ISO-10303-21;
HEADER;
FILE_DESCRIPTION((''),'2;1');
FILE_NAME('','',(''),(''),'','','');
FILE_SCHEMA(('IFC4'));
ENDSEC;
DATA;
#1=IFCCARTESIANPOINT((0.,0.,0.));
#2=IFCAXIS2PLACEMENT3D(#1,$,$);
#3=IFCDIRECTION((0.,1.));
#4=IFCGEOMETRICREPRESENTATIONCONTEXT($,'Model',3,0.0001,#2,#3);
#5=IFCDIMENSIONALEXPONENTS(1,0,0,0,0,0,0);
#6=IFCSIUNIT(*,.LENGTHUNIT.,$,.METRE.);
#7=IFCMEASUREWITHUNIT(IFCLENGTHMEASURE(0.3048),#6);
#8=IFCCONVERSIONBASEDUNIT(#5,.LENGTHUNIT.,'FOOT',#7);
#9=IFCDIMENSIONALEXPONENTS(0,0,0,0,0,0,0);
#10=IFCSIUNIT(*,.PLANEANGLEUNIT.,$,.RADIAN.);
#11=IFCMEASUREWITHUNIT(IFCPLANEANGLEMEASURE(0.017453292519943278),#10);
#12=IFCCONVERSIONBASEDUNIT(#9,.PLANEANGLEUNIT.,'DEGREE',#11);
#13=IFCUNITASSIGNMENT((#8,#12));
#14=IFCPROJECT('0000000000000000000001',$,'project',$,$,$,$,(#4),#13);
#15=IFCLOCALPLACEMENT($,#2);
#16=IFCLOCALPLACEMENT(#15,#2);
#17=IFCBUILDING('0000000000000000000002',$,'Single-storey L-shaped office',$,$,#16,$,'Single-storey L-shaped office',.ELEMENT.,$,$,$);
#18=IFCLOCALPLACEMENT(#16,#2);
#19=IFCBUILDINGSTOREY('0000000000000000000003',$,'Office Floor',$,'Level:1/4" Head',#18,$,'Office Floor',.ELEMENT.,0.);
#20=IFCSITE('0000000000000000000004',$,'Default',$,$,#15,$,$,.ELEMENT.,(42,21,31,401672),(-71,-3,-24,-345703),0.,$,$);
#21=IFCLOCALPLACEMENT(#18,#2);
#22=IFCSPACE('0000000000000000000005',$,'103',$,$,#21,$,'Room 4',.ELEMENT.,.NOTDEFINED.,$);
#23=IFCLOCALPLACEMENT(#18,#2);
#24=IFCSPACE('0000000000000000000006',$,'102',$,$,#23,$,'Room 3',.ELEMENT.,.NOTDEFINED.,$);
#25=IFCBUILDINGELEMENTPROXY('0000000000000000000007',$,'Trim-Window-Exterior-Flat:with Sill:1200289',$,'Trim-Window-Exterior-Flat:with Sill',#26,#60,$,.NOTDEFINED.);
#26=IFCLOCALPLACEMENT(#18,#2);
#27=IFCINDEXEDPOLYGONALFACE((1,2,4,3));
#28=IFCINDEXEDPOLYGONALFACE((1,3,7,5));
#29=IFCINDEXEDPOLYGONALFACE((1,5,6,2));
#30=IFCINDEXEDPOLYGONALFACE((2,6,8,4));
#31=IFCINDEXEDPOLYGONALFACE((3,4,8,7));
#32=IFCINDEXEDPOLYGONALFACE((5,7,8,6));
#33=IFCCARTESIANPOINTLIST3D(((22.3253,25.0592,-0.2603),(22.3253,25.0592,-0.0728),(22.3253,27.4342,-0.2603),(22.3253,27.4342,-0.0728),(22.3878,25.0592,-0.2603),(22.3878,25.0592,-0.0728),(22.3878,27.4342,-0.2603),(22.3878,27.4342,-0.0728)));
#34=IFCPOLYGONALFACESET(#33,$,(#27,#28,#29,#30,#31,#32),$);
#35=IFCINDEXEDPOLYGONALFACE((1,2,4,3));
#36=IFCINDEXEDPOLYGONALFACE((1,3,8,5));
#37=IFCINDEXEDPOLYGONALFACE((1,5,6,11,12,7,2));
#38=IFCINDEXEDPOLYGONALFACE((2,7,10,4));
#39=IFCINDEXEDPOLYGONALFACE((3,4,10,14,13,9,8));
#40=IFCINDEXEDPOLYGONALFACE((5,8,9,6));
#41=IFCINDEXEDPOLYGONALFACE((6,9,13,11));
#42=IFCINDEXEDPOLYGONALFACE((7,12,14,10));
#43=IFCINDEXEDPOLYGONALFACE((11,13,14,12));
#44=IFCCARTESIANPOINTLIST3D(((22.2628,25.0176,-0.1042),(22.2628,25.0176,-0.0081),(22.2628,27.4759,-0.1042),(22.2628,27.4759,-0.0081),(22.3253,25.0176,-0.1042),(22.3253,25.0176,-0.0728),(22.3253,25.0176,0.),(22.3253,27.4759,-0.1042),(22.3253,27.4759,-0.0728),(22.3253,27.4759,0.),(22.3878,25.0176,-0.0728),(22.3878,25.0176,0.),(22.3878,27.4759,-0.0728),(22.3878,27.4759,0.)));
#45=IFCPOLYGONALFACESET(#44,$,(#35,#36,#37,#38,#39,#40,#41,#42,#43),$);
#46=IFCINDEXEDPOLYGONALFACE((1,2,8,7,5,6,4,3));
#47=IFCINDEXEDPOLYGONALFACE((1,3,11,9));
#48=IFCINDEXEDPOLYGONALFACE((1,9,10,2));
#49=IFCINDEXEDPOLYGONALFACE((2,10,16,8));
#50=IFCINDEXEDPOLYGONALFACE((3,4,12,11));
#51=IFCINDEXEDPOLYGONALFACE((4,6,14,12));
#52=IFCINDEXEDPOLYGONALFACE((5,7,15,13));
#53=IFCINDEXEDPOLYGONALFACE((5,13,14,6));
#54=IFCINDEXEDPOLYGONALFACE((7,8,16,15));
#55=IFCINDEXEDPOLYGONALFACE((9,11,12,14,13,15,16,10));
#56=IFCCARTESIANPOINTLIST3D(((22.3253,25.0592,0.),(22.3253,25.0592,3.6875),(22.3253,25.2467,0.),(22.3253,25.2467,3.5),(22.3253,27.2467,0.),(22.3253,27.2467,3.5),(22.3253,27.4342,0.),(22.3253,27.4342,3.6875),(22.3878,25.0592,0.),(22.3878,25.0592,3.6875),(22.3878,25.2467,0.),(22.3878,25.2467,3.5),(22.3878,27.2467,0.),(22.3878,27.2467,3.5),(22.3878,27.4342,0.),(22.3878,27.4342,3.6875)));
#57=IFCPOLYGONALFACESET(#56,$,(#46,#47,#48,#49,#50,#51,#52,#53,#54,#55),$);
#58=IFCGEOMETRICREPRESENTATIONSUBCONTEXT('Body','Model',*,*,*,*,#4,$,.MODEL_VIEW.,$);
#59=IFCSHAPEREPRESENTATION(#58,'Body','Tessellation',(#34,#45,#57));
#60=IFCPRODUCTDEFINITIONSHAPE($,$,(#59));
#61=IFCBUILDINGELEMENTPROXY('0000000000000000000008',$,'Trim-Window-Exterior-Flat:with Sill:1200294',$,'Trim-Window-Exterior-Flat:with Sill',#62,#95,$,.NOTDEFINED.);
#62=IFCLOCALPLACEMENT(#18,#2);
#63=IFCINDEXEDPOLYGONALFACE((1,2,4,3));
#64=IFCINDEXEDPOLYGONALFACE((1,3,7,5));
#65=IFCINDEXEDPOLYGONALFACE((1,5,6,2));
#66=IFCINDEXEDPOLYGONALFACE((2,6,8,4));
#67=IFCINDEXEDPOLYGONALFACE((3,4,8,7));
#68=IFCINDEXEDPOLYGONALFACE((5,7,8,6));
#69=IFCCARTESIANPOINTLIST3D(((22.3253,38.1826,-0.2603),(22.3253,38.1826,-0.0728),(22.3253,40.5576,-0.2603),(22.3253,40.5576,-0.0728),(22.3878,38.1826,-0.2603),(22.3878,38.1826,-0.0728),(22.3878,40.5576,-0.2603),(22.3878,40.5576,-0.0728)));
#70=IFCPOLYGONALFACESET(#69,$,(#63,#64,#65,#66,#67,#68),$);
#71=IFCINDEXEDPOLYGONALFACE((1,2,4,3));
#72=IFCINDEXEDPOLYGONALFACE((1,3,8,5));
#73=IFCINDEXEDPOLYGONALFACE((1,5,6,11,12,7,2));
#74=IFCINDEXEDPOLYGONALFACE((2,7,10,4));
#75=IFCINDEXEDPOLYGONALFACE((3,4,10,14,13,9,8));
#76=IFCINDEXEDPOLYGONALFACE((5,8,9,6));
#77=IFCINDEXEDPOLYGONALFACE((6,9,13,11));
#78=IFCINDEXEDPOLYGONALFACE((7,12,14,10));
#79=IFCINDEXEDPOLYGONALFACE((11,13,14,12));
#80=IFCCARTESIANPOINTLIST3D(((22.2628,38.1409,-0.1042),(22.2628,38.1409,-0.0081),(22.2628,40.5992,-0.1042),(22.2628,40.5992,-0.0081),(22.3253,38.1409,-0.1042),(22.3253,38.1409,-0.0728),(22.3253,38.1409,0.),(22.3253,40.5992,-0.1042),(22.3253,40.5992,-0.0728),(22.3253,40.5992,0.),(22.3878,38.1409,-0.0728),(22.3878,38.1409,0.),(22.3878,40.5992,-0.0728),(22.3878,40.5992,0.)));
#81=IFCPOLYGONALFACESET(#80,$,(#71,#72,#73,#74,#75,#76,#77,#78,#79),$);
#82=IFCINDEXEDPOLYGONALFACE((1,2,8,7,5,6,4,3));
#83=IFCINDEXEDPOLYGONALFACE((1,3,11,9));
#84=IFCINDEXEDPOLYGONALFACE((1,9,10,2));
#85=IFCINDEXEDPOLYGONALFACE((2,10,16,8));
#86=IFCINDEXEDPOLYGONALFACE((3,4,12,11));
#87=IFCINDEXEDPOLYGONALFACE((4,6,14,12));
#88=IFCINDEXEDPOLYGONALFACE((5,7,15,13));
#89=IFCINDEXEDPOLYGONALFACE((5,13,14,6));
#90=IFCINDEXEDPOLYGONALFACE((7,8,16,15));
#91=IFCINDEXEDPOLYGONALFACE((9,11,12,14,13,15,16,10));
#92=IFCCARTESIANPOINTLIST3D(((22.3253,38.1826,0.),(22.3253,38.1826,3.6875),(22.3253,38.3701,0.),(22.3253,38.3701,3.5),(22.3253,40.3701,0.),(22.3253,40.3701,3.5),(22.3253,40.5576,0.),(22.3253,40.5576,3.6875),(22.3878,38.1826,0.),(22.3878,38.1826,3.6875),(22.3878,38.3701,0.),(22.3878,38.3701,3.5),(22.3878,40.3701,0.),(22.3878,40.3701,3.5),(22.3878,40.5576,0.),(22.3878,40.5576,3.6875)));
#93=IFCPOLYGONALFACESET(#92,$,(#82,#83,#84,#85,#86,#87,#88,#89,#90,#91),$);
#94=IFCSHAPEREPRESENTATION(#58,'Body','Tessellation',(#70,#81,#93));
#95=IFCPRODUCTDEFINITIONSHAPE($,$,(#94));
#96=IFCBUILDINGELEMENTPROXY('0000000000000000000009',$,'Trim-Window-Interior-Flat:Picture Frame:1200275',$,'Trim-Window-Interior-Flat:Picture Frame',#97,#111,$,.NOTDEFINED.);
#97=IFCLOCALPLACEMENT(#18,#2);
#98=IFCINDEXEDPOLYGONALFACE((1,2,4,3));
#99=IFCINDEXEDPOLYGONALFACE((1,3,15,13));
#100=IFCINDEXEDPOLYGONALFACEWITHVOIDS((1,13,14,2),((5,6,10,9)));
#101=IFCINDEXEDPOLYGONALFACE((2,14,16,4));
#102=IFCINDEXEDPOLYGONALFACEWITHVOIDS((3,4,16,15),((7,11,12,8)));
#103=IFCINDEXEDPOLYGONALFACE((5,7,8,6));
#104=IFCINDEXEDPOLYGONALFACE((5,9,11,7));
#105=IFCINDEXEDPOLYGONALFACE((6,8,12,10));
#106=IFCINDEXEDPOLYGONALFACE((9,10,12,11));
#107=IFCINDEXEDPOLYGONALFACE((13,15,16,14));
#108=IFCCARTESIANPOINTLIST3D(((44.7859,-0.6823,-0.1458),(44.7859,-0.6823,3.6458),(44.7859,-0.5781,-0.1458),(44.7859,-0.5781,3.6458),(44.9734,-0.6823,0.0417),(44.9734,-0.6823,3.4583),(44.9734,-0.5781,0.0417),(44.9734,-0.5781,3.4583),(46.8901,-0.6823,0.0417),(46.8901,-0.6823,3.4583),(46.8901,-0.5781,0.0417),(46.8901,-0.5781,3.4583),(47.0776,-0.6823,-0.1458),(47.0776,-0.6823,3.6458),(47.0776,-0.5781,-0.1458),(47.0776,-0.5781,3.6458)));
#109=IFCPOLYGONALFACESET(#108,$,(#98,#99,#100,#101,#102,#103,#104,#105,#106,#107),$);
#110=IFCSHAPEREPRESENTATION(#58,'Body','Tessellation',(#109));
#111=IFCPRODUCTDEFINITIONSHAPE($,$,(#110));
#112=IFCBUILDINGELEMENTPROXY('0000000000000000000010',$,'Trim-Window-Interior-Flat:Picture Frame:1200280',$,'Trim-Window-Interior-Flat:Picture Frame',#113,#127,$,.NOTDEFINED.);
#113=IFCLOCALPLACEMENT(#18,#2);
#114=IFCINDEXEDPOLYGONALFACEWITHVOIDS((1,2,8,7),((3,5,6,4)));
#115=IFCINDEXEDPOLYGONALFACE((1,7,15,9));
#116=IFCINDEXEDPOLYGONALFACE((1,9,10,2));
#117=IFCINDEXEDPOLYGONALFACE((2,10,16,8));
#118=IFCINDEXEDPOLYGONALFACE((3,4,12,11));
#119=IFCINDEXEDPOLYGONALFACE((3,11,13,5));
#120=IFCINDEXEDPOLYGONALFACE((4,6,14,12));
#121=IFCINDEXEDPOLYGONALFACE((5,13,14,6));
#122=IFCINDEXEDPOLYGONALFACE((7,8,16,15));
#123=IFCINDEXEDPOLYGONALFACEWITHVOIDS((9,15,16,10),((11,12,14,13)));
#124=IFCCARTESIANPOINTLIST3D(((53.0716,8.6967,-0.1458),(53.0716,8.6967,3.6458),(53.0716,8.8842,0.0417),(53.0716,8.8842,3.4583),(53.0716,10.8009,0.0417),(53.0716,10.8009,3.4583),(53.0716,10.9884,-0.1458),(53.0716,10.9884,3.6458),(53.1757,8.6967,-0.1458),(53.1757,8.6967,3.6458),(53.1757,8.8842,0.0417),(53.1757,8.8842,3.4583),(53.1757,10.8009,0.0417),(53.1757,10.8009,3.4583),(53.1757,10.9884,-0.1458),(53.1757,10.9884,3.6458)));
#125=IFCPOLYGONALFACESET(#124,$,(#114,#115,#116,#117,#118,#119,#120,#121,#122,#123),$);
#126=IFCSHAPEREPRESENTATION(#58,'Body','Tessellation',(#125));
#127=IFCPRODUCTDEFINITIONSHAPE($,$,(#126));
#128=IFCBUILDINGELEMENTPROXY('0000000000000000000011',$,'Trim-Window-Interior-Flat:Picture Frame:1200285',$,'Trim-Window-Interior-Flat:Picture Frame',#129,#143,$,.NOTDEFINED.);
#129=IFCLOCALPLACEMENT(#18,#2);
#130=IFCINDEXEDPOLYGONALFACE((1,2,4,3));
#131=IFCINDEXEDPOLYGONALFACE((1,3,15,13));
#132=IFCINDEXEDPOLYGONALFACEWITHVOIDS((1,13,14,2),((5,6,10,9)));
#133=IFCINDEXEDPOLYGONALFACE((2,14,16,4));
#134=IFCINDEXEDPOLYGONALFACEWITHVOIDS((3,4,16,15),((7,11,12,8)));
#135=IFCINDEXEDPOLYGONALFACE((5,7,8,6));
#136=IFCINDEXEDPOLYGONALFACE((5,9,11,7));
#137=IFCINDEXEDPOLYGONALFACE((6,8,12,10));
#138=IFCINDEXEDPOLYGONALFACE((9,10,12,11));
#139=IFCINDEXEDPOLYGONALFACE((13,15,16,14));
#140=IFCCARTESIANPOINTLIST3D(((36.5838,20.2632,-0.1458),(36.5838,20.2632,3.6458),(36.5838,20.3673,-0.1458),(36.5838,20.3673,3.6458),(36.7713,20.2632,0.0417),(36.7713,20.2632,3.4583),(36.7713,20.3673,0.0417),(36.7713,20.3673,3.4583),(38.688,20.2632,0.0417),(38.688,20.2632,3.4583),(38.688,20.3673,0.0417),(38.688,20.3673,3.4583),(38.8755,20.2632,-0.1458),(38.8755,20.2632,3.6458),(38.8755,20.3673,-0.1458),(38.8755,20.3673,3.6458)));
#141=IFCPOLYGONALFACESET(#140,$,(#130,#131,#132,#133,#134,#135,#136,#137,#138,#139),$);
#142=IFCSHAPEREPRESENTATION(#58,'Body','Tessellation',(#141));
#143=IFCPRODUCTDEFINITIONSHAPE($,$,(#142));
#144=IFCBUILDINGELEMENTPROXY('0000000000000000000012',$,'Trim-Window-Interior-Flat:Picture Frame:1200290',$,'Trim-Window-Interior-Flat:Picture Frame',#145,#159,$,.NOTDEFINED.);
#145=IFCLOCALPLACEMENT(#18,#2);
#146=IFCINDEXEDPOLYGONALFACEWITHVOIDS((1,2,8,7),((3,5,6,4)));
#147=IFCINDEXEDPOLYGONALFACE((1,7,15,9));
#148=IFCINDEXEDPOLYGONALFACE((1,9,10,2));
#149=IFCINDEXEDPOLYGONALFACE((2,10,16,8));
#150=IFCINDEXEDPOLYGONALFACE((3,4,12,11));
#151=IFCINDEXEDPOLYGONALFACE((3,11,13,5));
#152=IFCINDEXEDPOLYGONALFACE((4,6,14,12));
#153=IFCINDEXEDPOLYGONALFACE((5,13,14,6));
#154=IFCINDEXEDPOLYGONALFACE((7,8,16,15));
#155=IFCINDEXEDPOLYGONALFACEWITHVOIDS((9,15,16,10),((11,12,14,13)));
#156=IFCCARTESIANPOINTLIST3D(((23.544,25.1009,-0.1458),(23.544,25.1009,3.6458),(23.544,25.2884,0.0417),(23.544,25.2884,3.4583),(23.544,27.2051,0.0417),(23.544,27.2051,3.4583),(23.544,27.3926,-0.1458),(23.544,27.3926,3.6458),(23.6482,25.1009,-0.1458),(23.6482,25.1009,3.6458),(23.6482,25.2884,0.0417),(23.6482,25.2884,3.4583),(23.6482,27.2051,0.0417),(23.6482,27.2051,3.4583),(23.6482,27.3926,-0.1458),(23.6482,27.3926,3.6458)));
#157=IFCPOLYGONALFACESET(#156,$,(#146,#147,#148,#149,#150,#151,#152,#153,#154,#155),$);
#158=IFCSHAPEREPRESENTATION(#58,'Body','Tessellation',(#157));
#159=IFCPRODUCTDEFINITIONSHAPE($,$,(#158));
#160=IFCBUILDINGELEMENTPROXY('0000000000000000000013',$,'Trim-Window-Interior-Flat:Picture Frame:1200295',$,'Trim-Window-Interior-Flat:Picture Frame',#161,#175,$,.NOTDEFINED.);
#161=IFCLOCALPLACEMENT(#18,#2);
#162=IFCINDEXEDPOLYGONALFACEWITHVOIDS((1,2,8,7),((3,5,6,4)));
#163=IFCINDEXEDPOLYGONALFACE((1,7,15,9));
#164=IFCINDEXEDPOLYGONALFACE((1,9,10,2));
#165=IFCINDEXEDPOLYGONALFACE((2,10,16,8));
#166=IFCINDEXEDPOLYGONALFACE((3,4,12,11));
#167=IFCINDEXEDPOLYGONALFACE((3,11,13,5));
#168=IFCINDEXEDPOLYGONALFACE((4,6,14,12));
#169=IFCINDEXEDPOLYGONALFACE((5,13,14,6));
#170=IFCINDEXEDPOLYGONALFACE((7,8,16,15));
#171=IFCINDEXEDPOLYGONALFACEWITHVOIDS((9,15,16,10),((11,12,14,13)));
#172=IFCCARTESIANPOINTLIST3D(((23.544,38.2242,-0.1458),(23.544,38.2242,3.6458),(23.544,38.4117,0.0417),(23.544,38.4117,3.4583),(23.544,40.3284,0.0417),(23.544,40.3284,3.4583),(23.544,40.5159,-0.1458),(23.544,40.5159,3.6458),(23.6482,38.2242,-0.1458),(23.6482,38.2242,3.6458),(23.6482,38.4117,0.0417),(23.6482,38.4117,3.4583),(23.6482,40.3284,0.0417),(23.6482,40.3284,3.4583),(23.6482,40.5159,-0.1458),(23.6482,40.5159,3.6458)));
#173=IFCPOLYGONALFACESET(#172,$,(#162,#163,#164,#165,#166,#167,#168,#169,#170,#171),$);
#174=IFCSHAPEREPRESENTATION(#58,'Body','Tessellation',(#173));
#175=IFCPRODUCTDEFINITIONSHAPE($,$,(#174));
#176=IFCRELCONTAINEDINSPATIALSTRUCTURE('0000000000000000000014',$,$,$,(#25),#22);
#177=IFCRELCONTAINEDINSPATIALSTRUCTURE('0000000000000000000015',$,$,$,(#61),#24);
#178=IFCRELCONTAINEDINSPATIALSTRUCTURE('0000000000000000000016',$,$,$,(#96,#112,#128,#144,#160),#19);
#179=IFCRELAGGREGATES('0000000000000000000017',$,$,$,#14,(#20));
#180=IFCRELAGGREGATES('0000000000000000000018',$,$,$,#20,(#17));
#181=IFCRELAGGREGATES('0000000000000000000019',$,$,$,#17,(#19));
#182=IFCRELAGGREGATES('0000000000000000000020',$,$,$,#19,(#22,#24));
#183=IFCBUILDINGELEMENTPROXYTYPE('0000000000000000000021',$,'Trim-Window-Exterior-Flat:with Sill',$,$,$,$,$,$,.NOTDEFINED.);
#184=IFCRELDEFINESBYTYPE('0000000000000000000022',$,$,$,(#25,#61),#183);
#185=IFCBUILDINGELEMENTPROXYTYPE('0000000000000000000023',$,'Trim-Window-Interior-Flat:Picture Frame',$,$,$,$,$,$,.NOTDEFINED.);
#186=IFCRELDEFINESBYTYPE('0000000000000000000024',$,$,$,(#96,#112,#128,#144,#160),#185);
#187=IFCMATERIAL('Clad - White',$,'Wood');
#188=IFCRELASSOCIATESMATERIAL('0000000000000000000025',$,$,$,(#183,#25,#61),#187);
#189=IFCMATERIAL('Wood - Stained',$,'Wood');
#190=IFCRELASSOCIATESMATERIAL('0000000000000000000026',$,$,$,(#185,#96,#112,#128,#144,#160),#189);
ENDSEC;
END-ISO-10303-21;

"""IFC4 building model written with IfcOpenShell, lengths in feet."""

from ifc_helpers import new_model, entity, si_unit, converted_unit, direction, frame, origin, place, context, subcontext, project, spatial, indexed_curve, outline, extrude, source, transform, mapped, material, type_object, type_shapes, element, save


model = new_model("IFC4")

# Units and contexts
model_context = context("Model", 3, precision=0.0001, world=origin(), true_north=direction((0.0, 1.0)))
body_context = subcontext(model_context, "Body", "Model", "MODEL_VIEW")
ifc_project = project(units=[converted_unit("LENGTHUNIT", "FOOT", entity("IfcLengthMeasure", 0.3048), si_unit("LENGTHUNIT", "METRE"), dimensions=[1, 0, 0, 0, 0, 0, 0]), converted_unit("PLANEANGLEUNIT", "DEGREE", entity("IfcPlaneAngleMeasure", 0.017453292519943278), si_unit("PLANEANGLEUNIT", "RADIAN"), dimensions=[0, 0, 0, 0, 0, 0, 0])], contexts=[model_context])

# Site, building, storey
site_placement = place(None, origin())
site = spatial("IfcSite", under=ifc_project, at=site_placement, Name="Default", CompositionType="ELEMENT", RefLatitude=(42, 21, 31, 401672), RefLongitude=(-71, -3, -24, -345703), RefElevation=0.0)
building_placement = place(site_placement, origin())
building = spatial("IfcBuilding", under=site, at=building_placement, Name="Single-storey L-shaped office", LongName="Single-storey L-shaped office", CompositionType="ELEMENT")
storey_placement = place(building_placement, origin())
storey = spatial("IfcBuildingStorey", under=building, at=storey_placement, Name="Office Floor", ObjectType="Level:1/4\" Head", LongName="Office Floor", CompositionType="ELEMENT", Elevation=0.0)

# Shared definitions
ifc_material_1 = material(Name="Wood - Stained", Category="Wood")

# Shared definitions
ifc_material_2 = material(Name="Clad - White", Category="Wood")

# Shared definitions
building_element_proxy_type_1 = type_object("IfcBuildingElementProxyType", Name="Trim-Window-Exterior-Flat:with Sill", PredefinedType="NOTDEFINED", material=ifc_material_2)
shared_shape_1 = source(origin(), body_context, "Body", "SweptSolid", [
    extrude(outline(indexed_curve([(-1.1875, -0.0938), (1.1875, -0.0938), (1.1875, 0.0938), (-1.1875, 0.0938), (-1.1875, -0.0938)], self_intersect=False)), frame((0.0, -3.6665, 0.0), z_axis=(0.0, 0.0, 1.0), x_axis=(-1.0, 0.0, 0.0)), (0.0, 0.0, 1.0), 0.0625),
    extrude(outline(indexed_curve([(-0.0625, -0.0525), (0.0, -0.0525), (0.0, -0.0211), (0.0625, -0.0211), (0.0625, 0.0517), (0.0, 0.0517), (-0.0625, 0.0436), (-0.0625, -0.0525)], self_intersect=False)), frame((-1.2292, -3.5517, 0.0625), z_axis=(1.0, 0.0, 0.0), x_axis=(0.0, 0.0, -1.0)), (0.0, 0.0, 1.0), 2.4583),
    extrude(outline(indexed_curve([(-1.8906, -1.1875), (1.7969, -1.1875), (1.7969, -1.0), (-1.7031, -1.0), (-1.7031, 1.0), (1.7969, 1.0), (1.7969, 1.1875), (-1.8906, 1.1875), (-1.8906, -1.1875)], self_intersect=False)), frame((0.0, -1.7031, 0.0), z_axis=(0.0, 0.0, 1.0), x_axis=(0.0, -1.0, 0.0)), (0.0, 0.0, 1.0), 0.0625),
])
type_shapes(building_element_proxy_type_1, [shared_shape_1])

# Shared definitions
space_1_placement = place(storey_placement, origin())
space_1 = spatial("IfcSpace", under=storey, at=space_1_placement, Name="103", LongName="Room 4", CompositionType="ELEMENT", PredefinedType="NOTDEFINED")

# Building element proxy
proxy_1_placement = place(space_1_placement, frame((22.3878, 26.2467, 3.5), z_axis=(-1.0, 0.0, 0.0), x_axis=(0.0, -1.0, 0.0)))
element("IfcBuildingElementProxy", 1, at=proxy_1_placement, inside=space_1, type_object=building_element_proxy_type_1, material=ifc_material_2, Name="Trim-Window-Exterior-Flat:with Sill:1200289", ObjectType="Trim-Window-Exterior-Flat:with Sill", PredefinedType="NOTDEFINED", context=body_context, shape_type="MappedRepresentation", body=[
    mapped(shared_shape_1, transform((0.0, 0.0, 0.0), scale=1.0)),
])

# Shared definitions
space_2_placement = place(storey_placement, origin())
space_2 = spatial("IfcSpace", under=storey, at=space_2_placement, Name="102", LongName="Room 3", CompositionType="ELEMENT", PredefinedType="NOTDEFINED")

# Building element proxies
proxy_2_placement = place(space_2_placement, frame((22.3878, 39.3701, 3.5), z_axis=(-1.0, 0.0, 0.0), x_axis=(0.0, -1.0, 0.0)))
element("IfcBuildingElementProxy", 2, at=proxy_2_placement, inside=space_2, type_object=building_element_proxy_type_1, material=ifc_material_2, Name="Trim-Window-Exterior-Flat:with Sill:1200294", ObjectType="Trim-Window-Exterior-Flat:with Sill", PredefinedType="NOTDEFINED", context=body_context, shape_type="MappedRepresentation", body=[
    mapped(shared_shape_1, transform((0.0, 0.0, 0.0), scale=1.0)),
])
building_element_proxy_type_2 = type_object("IfcBuildingElementProxyType", Name="Trim-Window-Interior-Flat:Picture Frame", PredefinedType="NOTDEFINED", material=ifc_material_1)
shared_shape_2 = source(origin(), body_context, "Body", "SweptSolid", [
    extrude(outline(indexed_curve([(-1.1458, -1.8958), (1.1458, -1.8958), (1.1458, 1.8958), (-1.1458, 1.8958), (-1.1458, -1.8958)], self_intersect=False), holes=[indexed_curve([(-0.9583, -1.7083), (-0.9583, 1.7083), (0.9583, 1.7083), (0.9583, -1.7083), (-0.9583, -1.7083)], self_intersect=False)]), frame((0.0, -1.75, 0.0), z_axis=(0.0, 0.0, 1.0), x_axis=(-1.0, 0.0, 0.0)), (0.0, 0.0, 1.0), 0.1042),
])
type_shapes(building_element_proxy_type_2, [shared_shape_2])
for number, where, z_axis, x_axis, name in (
    (3, (45.9318, -0.5781, 3.5), (0.0, -1.0, 0.0), (1.0, 0.0, 0.0), "Trim-Window-Interior-Flat:Picture Frame:1200275"),
    (4, (53.0716, 9.8425, 3.5), (1.0, 0.0, 0.0), (0.0, 1.0, 0.0), "Trim-Window-Interior-Flat:Picture Frame:1200280"),
    (5, (37.7297, 20.2632, 3.5), (0.0, 1.0, 0.0), (-1.0, 0.0, 0.0), "Trim-Window-Interior-Flat:Picture Frame:1200285"),
    (6, (23.544, 26.2467, 3.5), (1.0, 0.0, 0.0), (0.0, 1.0, 0.0), "Trim-Window-Interior-Flat:Picture Frame:1200290"),
    (7, (23.544, 39.3701, 3.5), (1.0, 0.0, 0.0), (0.0, 1.0, 0.0), "Trim-Window-Interior-Flat:Picture Frame:1200295"),
):
    element("IfcBuildingElementProxy", number, at=place(storey_placement, frame(where, z_axis=z_axis, x_axis=x_axis)), inside=storey, type_object=building_element_proxy_type_2, material=ifc_material_1, Name=name, ObjectType="Trim-Window-Interior-Flat:Picture Frame", PredefinedType="NOTDEFINED", context=body_context, shape_type="MappedRepresentation", body=[
        mapped(shared_shape_2, transform((0.0, 0.0, 0.0), scale=1.0)),
    ])

save(model, "model.ifc")
